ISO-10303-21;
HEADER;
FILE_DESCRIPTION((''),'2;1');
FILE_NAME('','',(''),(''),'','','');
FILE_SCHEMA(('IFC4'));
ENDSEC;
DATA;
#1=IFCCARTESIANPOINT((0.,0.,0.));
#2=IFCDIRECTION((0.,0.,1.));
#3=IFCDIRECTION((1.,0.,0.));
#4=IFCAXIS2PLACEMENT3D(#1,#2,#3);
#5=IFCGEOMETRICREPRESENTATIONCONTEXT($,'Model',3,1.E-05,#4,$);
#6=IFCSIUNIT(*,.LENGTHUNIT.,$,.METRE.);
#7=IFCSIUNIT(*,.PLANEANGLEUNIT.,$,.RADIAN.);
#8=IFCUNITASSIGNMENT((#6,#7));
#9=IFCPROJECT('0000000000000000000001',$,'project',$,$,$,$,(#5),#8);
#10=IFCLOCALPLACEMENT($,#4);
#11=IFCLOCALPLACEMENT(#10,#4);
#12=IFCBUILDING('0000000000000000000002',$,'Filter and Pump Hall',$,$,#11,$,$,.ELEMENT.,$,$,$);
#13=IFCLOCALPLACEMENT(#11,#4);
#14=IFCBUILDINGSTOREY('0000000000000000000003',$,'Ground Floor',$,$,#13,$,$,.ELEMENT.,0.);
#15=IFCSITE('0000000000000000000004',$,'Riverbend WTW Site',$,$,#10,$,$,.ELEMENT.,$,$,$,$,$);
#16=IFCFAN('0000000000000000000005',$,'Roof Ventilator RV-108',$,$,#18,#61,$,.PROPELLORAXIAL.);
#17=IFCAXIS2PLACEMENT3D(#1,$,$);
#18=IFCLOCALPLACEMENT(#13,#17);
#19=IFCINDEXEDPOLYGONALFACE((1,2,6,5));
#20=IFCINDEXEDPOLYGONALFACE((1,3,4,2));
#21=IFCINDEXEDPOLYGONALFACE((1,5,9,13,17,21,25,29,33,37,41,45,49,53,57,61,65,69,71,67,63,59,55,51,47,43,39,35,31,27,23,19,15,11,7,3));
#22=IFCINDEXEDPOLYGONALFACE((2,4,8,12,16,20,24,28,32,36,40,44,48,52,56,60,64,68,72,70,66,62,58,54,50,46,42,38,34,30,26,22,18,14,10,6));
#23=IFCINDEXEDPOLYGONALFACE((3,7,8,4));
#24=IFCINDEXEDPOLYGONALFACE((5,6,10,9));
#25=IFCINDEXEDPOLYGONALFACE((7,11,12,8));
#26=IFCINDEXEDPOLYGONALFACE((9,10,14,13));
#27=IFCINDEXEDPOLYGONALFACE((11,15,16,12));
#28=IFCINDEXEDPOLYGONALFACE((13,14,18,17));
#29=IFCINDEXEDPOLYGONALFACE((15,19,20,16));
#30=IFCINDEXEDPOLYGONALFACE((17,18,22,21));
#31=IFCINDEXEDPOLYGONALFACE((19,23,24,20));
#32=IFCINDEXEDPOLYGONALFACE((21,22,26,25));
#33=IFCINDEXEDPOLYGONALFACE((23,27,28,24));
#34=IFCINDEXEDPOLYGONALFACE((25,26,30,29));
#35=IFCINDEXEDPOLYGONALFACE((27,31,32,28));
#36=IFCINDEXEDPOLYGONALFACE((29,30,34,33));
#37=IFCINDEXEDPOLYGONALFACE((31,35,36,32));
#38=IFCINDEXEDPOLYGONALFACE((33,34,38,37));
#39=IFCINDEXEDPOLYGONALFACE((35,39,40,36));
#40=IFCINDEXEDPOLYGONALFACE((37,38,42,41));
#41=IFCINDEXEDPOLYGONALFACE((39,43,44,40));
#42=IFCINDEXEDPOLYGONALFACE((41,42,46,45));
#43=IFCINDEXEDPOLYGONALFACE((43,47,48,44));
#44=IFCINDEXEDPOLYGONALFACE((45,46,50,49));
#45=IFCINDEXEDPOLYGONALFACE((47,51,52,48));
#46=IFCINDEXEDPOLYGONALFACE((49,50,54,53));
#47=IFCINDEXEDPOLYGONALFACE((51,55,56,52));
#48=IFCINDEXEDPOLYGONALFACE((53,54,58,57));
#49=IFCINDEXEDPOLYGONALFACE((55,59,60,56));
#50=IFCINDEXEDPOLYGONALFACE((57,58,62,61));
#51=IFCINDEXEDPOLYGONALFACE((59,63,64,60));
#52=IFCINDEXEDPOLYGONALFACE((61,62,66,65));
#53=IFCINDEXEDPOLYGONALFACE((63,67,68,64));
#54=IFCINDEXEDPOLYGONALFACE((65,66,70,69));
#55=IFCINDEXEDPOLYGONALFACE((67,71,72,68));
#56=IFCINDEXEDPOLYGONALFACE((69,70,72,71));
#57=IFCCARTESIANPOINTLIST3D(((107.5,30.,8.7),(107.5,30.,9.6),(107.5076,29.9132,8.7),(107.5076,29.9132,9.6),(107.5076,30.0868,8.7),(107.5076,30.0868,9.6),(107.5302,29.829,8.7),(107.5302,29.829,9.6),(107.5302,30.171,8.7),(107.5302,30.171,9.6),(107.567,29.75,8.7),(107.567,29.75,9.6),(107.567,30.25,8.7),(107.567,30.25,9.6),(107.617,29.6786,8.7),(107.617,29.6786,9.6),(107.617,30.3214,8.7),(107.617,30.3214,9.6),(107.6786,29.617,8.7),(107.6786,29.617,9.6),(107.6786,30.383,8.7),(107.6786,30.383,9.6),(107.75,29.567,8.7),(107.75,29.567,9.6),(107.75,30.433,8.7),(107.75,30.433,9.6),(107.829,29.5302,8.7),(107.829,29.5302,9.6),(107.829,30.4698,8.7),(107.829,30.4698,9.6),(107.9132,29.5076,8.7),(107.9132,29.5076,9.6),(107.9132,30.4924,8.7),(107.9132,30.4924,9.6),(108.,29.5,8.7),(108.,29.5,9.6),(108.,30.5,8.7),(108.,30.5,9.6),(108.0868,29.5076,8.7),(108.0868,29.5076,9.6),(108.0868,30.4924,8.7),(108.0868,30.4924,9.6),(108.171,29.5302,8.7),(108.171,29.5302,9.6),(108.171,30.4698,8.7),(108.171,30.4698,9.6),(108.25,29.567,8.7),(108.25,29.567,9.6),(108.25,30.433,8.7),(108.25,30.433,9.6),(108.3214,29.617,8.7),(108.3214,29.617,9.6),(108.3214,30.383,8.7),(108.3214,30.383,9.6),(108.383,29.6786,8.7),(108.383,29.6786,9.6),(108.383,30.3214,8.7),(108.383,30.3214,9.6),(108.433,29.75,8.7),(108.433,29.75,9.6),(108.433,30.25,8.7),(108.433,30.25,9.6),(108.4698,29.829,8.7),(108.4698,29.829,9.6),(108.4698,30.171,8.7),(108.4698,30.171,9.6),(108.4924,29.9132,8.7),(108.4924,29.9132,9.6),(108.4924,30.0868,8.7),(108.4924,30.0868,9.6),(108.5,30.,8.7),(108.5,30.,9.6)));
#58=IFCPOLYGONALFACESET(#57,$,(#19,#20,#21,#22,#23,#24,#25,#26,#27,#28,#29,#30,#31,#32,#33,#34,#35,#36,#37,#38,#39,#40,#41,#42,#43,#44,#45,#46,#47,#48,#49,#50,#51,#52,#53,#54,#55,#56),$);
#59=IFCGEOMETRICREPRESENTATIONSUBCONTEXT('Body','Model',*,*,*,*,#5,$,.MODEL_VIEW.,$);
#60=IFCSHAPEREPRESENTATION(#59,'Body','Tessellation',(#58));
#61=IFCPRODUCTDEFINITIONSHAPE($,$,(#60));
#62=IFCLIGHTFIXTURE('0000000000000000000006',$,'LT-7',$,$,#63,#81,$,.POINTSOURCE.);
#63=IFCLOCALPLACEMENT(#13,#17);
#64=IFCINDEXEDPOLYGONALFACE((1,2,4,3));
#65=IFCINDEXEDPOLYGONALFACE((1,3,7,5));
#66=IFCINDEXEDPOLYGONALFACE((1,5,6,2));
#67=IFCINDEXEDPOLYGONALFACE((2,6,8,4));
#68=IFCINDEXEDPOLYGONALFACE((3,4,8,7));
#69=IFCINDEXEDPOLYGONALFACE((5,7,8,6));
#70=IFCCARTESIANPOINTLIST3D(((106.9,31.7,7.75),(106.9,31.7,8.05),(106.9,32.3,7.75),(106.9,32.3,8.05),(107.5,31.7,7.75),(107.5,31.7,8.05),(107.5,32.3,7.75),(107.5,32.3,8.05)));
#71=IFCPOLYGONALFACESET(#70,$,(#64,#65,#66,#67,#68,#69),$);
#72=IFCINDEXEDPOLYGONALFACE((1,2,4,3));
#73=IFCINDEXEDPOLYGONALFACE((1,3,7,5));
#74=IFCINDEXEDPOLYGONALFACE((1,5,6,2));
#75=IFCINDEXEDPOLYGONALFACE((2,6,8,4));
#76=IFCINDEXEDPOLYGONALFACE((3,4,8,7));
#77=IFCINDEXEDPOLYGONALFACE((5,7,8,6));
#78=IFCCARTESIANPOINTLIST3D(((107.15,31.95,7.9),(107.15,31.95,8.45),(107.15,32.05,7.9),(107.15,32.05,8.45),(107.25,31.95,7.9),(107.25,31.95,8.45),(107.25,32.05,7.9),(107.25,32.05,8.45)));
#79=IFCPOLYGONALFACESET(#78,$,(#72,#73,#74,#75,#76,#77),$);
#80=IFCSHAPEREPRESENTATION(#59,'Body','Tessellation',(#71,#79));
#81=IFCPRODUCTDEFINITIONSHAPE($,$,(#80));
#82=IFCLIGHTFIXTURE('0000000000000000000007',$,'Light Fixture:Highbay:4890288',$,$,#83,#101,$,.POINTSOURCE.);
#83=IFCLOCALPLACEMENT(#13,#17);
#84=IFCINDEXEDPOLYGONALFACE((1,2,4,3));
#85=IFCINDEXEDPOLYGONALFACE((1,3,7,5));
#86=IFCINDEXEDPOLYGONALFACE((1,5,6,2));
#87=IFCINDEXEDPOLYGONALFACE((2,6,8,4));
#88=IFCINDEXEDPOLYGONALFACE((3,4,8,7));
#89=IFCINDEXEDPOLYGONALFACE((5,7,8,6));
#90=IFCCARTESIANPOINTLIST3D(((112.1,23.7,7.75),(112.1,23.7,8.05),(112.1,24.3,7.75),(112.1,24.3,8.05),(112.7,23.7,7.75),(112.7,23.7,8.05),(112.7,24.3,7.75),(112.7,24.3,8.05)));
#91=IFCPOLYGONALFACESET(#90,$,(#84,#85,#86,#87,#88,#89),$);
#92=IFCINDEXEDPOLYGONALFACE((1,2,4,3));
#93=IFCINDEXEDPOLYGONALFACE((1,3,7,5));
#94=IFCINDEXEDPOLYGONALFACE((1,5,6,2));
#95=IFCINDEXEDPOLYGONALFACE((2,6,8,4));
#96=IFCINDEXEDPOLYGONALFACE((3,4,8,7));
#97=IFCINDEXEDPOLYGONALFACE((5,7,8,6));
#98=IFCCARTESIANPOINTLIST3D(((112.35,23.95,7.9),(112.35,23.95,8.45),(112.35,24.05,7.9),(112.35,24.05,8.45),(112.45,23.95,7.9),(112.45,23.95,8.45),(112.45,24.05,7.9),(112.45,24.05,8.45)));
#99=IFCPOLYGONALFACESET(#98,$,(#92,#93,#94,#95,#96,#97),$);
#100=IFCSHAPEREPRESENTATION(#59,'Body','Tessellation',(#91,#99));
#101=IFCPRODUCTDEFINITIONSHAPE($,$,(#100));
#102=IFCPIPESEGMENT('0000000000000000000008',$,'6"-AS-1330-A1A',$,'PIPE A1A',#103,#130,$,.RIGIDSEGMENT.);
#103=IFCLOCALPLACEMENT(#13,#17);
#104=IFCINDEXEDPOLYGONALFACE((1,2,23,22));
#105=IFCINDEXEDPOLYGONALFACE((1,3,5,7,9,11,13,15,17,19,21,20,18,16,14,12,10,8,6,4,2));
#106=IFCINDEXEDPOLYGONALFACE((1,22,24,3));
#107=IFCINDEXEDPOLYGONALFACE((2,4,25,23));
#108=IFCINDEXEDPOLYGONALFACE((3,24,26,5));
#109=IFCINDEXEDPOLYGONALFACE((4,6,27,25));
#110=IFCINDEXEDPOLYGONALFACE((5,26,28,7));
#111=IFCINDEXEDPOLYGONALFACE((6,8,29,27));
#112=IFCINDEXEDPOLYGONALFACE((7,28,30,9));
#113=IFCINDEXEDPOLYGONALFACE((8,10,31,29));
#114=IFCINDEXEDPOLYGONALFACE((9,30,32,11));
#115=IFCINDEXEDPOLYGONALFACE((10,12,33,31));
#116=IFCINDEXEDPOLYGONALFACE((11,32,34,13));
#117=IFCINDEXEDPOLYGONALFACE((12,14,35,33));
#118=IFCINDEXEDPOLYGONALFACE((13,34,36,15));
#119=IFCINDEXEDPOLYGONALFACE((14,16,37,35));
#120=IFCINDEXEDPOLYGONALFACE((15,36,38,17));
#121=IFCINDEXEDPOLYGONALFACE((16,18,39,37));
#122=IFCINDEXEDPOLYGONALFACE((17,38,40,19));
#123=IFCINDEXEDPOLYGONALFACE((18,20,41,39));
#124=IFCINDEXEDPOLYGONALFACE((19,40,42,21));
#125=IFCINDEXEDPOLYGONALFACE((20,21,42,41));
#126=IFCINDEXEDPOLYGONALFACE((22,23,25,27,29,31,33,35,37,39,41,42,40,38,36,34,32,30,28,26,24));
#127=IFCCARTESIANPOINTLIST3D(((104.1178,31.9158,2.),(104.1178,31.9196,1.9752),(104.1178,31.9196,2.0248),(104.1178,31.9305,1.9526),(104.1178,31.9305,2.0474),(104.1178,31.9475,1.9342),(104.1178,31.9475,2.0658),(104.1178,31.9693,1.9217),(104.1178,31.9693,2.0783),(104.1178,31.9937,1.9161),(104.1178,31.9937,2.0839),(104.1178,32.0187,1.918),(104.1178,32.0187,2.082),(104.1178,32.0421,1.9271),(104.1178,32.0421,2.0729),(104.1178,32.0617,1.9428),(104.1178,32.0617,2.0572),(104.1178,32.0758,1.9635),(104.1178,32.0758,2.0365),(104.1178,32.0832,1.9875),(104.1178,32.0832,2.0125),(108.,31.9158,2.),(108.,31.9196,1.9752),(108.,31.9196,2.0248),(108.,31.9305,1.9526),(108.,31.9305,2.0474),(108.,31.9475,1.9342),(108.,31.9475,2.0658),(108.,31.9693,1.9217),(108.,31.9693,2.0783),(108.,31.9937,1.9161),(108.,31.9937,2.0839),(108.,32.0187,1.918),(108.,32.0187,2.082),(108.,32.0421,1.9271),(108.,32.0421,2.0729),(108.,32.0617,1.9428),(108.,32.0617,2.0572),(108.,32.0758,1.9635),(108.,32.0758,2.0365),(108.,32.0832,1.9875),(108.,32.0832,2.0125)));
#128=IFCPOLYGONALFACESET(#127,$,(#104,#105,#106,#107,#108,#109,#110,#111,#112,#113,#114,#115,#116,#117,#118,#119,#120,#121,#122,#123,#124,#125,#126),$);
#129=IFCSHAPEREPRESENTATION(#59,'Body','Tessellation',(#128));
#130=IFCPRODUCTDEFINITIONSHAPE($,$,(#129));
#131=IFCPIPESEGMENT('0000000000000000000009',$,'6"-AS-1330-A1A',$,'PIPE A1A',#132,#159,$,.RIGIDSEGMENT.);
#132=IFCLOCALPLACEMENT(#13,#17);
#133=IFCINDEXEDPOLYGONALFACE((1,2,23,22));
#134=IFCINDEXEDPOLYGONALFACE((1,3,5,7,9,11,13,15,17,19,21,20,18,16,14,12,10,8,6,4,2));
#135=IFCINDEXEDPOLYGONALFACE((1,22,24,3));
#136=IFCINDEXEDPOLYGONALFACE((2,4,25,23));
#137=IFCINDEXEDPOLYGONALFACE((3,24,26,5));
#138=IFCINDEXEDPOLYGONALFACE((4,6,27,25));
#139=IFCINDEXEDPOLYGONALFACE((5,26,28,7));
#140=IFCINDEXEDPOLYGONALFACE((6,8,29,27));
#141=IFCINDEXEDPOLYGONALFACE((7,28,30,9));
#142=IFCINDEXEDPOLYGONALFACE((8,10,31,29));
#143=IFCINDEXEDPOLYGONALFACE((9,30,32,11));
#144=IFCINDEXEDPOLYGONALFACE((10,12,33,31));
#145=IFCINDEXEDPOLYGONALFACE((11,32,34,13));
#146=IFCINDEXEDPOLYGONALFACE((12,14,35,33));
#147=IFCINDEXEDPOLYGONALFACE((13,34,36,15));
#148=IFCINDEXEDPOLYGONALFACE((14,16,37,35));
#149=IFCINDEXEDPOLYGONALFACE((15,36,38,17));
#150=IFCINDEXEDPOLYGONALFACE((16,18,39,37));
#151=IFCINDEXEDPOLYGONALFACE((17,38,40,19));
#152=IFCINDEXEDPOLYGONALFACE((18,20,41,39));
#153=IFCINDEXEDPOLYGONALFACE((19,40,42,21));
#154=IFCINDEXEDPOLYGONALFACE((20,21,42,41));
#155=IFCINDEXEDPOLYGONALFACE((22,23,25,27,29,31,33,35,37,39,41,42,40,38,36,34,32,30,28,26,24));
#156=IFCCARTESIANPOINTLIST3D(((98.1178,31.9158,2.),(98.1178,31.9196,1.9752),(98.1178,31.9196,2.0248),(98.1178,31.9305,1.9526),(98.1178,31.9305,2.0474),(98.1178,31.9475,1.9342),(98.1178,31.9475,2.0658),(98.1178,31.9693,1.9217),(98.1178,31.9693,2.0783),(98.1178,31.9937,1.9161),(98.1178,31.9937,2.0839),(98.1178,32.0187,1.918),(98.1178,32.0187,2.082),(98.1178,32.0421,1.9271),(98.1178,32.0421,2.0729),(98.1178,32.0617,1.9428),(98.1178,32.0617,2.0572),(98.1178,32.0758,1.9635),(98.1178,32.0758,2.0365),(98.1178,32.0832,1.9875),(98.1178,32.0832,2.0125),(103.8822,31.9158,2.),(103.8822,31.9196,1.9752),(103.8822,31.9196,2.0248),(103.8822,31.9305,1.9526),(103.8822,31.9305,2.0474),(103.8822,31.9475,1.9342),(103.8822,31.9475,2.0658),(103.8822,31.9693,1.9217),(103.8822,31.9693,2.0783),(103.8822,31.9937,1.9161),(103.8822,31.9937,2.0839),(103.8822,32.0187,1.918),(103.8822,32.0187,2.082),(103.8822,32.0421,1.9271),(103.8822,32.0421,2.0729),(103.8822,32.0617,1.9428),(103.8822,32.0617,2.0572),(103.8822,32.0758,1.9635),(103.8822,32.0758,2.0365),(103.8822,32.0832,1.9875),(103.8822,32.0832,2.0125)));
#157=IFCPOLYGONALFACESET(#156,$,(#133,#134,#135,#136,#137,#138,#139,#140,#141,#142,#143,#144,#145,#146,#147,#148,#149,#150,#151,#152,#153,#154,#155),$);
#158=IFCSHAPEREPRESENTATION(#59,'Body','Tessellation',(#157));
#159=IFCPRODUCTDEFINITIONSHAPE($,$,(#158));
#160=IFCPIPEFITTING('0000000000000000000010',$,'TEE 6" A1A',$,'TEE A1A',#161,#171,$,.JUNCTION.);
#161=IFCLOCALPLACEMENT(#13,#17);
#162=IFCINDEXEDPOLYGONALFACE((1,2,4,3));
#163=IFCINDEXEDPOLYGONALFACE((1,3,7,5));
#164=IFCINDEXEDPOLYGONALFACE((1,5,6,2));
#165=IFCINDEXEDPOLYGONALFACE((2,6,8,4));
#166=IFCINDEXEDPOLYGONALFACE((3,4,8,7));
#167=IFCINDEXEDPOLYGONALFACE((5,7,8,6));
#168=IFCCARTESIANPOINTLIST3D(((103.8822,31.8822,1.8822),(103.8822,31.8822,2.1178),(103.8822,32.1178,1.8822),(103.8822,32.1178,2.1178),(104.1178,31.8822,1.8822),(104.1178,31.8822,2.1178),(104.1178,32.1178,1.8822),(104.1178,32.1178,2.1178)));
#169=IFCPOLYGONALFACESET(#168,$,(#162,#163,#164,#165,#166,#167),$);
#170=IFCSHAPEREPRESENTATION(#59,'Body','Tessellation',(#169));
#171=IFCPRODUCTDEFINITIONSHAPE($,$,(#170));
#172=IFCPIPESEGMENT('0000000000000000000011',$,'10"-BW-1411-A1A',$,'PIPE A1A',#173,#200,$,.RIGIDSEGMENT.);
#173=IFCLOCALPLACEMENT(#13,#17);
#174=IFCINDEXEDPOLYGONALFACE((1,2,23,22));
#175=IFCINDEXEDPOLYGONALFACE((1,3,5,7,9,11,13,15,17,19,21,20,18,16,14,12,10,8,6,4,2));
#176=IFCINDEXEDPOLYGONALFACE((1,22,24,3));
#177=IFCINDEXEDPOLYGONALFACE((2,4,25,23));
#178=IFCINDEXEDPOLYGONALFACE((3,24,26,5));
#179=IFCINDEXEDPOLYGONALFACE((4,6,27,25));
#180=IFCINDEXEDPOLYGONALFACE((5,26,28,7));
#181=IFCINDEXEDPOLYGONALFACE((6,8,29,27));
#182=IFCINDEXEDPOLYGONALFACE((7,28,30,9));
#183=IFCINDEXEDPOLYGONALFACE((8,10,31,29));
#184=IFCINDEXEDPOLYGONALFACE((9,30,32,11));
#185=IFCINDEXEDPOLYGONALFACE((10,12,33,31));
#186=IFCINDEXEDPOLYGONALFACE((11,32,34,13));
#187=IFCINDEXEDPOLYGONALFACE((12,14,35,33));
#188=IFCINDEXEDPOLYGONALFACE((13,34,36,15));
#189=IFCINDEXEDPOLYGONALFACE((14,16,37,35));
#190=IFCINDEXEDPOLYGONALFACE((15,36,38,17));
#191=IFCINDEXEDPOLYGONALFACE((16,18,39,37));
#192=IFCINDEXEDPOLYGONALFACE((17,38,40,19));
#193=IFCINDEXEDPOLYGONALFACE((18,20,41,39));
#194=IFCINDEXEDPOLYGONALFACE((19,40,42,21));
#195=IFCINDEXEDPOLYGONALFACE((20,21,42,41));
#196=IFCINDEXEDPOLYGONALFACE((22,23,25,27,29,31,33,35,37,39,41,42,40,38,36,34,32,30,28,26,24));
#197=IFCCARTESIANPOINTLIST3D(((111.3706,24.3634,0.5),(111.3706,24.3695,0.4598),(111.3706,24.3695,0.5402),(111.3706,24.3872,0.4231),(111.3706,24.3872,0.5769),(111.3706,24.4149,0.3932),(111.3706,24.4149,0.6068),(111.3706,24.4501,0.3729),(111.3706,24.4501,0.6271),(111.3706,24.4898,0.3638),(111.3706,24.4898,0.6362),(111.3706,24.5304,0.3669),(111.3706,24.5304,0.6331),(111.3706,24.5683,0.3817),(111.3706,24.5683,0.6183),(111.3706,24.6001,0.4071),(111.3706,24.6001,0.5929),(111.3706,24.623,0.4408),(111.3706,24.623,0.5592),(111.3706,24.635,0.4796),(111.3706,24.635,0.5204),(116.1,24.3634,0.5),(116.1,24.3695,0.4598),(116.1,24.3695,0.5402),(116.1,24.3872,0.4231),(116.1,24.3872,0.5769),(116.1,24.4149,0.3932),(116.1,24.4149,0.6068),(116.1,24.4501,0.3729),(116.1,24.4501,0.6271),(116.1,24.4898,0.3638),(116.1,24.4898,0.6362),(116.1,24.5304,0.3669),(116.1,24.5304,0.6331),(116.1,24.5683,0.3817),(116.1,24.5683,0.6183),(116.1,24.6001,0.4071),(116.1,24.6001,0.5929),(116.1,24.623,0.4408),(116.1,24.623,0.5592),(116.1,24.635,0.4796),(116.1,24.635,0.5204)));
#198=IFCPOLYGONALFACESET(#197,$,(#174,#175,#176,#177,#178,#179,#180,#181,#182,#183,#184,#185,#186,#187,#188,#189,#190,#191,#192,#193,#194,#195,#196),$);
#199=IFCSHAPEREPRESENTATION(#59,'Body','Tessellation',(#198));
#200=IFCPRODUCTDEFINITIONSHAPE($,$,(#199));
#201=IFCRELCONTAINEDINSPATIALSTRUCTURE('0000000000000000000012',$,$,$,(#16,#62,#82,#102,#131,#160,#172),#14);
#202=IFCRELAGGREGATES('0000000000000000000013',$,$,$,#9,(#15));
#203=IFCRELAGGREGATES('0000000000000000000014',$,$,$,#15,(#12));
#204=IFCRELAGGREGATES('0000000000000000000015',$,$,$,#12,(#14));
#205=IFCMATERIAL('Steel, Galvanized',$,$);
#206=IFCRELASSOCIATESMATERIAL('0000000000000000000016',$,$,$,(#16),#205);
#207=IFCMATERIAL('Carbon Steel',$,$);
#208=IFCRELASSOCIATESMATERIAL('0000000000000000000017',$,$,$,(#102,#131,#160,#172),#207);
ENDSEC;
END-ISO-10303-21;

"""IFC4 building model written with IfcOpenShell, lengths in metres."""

from ifc_helpers import new_model, si_unit, frame, origin_with_axes, origin_2d, place, context, subcontext, project, spatial, rectangle, circle, extrude, material, element, save


model = new_model("IFC4")

# Units and contexts
model_context = context("Model", 3, precision=1e-05, world=origin_with_axes())
body_context = subcontext(model_context, "Body", "Model", "MODEL_VIEW")
ifc_project = project(units=[si_unit("LENGTHUNIT", "METRE"), si_unit("PLANEANGLEUNIT", "RADIAN")], contexts=[model_context])

# Site, building, storey
site_placement = place(None, origin_with_axes())
site = spatial("IfcSite", under=ifc_project, at=site_placement, Name="Riverbend WTW Site", CompositionType="ELEMENT")
building_placement = place(site_placement, origin_with_axes())
building = spatial("IfcBuilding", under=site, at=building_placement, Name="Filter and Pump Hall", CompositionType="ELEMENT")
storey_placement = place(building_placement, origin_with_axes())
storey = spatial("IfcBuildingStorey", under=building, at=storey_placement, Name="Ground Floor", CompositionType="ELEMENT", Elevation=0.0)

# Shared definitions
ifc_material_1 = material(Name="Steel, Galvanized")

# Fan
fan_placement = place(None, frame((108.0, 30.0, 8.7), z_axis=(0.0, 0.0, 1.0), x_axis=(1.0, 0.0, 0.0)))
element("IfcFan", 1, at=fan_placement, inside=storey, material=ifc_material_1, Name="Roof Ventilator RV-108", PredefinedType="PROPELLORAXIAL", context=body_context, shape_type="SweptSolid", body=[
    extrude(circle(Radius=0.5, at=origin_2d()), origin_with_axes(), (0.0, 0.0, 1.0), 0.9),
])

# Light fixtures
for number, where, z_axis, x_axis, name in (
    (2, (107.2, 32.0, 7.9), (0.0, 0.0, 1.0), (1.0, 0.0, 0.0), "LT-7"),
    (3, (112.4, 24.0, 7.9), (0.0, 0.0, 1.0), (1.0, 0.0, 0.0), "Light Fixture:Highbay:4890288"),
):
    element("IfcLightFixture", number, at=place(None, frame(where, z_axis=z_axis, x_axis=x_axis)), inside=storey, Name=name, PredefinedType="POINTSOURCE", context=body_context, shape_type="SweptSolid", body=[
        extrude(rectangle(XDim=0.6, YDim=0.6, at=origin_2d()), frame((0.0, 0.0, -0.15), z_axis=(0.0, 0.0, 1.0), x_axis=(1.0, 0.0, 0.0)), (0.0, 0.0, 1.0), 0.3),
        extrude(rectangle(XDim=0.1, YDim=0.1, at=origin_2d()), origin_with_axes(), (0.0, 0.0, 1.0), 0.55),
    ])

# Pipe segments
ifc_material_2 = material(Name="Carbon Steel")
pipe_segment_1_placement = place(None, frame((108.0, 32.0, 2.0), z_axis=(0.0, 0.0, 1.0), x_axis=(1.0, 0.0, 0.0)))
element("IfcPipeSegment", 4, at=pipe_segment_1_placement, inside=storey, material=ifc_material_2, Name="6\"-AS-1330-A1A", ObjectType="PIPE A1A", PredefinedType="RIGIDSEGMENT", context=body_context, shape_type="SweptSolid", body=[
    extrude(circle(Radius=0.0842, at=origin_2d()), frame((0.0, 0.0, 0.0), z_axis=(-1.0, 0.0, 0.0), x_axis=(0.0, -1.0, 0.0)), (0.0, 0.0, 1.0), 3.8822),
])
pipe_segment_2_placement = place(None, frame((103.8822, 32.0, 2.0), z_axis=(0.0, 0.0, 1.0), x_axis=(1.0, 0.0, 0.0)))
element("IfcPipeSegment", 5, at=pipe_segment_2_placement, inside=storey, material=ifc_material_2, Name="6\"-AS-1330-A1A", ObjectType="PIPE A1A", PredefinedType="RIGIDSEGMENT", context=body_context, shape_type="SweptSolid", body=[
    extrude(circle(Radius=0.0842, at=origin_2d()), frame((0.0, 0.0, 0.0), z_axis=(-1.0, 0.0, 0.0), x_axis=(0.0, -1.0, 0.0)), (0.0, 0.0, 1.0), 5.7644),
])

# Pipe fitting
pipe_fitting_1_placement = place(None, frame((104.0, 32.0, 2.0), z_axis=(0.0, 0.0, 1.0), x_axis=(1.0, 0.0, 0.0)))
element("IfcPipeFitting", 6, at=pipe_fitting_1_placement, inside=storey, material=ifc_material_2, Name="TEE 6\" A1A", ObjectType="TEE A1A", PredefinedType="JUNCTION", context=body_context, shape_type="SweptSolid", body=[
    extrude(rectangle(XDim=0.2356, YDim=0.2356, at=origin_2d()), frame((0.0, 0.0, -0.1178), z_axis=(0.0, 0.0, 1.0), x_axis=(1.0, 0.0, 0.0)), (0.0, 0.0, 1.0), 0.2356),
])

# Pipe segment
pipe_segment_3_placement = place(None, frame((116.1, 24.5, 0.5), z_axis=(0.0, 0.0, 1.0), x_axis=(1.0, 0.0, 0.0)))
element("IfcPipeSegment", 7, at=pipe_segment_3_placement, inside=storey, material=ifc_material_2, Name="10\"-BW-1411-A1A", ObjectType="PIPE A1A", PredefinedType="RIGIDSEGMENT", context=body_context, shape_type="SweptSolid", body=[
    extrude(circle(Radius=0.1366, at=origin_2d()), frame((0.0, 0.0, 0.0), z_axis=(-1.0, 0.0, 0.0), x_axis=(0.0, -1.0, 0.0)), (0.0, 0.0, 1.0), 4.7294),
])

save(model, "model.ifc")
